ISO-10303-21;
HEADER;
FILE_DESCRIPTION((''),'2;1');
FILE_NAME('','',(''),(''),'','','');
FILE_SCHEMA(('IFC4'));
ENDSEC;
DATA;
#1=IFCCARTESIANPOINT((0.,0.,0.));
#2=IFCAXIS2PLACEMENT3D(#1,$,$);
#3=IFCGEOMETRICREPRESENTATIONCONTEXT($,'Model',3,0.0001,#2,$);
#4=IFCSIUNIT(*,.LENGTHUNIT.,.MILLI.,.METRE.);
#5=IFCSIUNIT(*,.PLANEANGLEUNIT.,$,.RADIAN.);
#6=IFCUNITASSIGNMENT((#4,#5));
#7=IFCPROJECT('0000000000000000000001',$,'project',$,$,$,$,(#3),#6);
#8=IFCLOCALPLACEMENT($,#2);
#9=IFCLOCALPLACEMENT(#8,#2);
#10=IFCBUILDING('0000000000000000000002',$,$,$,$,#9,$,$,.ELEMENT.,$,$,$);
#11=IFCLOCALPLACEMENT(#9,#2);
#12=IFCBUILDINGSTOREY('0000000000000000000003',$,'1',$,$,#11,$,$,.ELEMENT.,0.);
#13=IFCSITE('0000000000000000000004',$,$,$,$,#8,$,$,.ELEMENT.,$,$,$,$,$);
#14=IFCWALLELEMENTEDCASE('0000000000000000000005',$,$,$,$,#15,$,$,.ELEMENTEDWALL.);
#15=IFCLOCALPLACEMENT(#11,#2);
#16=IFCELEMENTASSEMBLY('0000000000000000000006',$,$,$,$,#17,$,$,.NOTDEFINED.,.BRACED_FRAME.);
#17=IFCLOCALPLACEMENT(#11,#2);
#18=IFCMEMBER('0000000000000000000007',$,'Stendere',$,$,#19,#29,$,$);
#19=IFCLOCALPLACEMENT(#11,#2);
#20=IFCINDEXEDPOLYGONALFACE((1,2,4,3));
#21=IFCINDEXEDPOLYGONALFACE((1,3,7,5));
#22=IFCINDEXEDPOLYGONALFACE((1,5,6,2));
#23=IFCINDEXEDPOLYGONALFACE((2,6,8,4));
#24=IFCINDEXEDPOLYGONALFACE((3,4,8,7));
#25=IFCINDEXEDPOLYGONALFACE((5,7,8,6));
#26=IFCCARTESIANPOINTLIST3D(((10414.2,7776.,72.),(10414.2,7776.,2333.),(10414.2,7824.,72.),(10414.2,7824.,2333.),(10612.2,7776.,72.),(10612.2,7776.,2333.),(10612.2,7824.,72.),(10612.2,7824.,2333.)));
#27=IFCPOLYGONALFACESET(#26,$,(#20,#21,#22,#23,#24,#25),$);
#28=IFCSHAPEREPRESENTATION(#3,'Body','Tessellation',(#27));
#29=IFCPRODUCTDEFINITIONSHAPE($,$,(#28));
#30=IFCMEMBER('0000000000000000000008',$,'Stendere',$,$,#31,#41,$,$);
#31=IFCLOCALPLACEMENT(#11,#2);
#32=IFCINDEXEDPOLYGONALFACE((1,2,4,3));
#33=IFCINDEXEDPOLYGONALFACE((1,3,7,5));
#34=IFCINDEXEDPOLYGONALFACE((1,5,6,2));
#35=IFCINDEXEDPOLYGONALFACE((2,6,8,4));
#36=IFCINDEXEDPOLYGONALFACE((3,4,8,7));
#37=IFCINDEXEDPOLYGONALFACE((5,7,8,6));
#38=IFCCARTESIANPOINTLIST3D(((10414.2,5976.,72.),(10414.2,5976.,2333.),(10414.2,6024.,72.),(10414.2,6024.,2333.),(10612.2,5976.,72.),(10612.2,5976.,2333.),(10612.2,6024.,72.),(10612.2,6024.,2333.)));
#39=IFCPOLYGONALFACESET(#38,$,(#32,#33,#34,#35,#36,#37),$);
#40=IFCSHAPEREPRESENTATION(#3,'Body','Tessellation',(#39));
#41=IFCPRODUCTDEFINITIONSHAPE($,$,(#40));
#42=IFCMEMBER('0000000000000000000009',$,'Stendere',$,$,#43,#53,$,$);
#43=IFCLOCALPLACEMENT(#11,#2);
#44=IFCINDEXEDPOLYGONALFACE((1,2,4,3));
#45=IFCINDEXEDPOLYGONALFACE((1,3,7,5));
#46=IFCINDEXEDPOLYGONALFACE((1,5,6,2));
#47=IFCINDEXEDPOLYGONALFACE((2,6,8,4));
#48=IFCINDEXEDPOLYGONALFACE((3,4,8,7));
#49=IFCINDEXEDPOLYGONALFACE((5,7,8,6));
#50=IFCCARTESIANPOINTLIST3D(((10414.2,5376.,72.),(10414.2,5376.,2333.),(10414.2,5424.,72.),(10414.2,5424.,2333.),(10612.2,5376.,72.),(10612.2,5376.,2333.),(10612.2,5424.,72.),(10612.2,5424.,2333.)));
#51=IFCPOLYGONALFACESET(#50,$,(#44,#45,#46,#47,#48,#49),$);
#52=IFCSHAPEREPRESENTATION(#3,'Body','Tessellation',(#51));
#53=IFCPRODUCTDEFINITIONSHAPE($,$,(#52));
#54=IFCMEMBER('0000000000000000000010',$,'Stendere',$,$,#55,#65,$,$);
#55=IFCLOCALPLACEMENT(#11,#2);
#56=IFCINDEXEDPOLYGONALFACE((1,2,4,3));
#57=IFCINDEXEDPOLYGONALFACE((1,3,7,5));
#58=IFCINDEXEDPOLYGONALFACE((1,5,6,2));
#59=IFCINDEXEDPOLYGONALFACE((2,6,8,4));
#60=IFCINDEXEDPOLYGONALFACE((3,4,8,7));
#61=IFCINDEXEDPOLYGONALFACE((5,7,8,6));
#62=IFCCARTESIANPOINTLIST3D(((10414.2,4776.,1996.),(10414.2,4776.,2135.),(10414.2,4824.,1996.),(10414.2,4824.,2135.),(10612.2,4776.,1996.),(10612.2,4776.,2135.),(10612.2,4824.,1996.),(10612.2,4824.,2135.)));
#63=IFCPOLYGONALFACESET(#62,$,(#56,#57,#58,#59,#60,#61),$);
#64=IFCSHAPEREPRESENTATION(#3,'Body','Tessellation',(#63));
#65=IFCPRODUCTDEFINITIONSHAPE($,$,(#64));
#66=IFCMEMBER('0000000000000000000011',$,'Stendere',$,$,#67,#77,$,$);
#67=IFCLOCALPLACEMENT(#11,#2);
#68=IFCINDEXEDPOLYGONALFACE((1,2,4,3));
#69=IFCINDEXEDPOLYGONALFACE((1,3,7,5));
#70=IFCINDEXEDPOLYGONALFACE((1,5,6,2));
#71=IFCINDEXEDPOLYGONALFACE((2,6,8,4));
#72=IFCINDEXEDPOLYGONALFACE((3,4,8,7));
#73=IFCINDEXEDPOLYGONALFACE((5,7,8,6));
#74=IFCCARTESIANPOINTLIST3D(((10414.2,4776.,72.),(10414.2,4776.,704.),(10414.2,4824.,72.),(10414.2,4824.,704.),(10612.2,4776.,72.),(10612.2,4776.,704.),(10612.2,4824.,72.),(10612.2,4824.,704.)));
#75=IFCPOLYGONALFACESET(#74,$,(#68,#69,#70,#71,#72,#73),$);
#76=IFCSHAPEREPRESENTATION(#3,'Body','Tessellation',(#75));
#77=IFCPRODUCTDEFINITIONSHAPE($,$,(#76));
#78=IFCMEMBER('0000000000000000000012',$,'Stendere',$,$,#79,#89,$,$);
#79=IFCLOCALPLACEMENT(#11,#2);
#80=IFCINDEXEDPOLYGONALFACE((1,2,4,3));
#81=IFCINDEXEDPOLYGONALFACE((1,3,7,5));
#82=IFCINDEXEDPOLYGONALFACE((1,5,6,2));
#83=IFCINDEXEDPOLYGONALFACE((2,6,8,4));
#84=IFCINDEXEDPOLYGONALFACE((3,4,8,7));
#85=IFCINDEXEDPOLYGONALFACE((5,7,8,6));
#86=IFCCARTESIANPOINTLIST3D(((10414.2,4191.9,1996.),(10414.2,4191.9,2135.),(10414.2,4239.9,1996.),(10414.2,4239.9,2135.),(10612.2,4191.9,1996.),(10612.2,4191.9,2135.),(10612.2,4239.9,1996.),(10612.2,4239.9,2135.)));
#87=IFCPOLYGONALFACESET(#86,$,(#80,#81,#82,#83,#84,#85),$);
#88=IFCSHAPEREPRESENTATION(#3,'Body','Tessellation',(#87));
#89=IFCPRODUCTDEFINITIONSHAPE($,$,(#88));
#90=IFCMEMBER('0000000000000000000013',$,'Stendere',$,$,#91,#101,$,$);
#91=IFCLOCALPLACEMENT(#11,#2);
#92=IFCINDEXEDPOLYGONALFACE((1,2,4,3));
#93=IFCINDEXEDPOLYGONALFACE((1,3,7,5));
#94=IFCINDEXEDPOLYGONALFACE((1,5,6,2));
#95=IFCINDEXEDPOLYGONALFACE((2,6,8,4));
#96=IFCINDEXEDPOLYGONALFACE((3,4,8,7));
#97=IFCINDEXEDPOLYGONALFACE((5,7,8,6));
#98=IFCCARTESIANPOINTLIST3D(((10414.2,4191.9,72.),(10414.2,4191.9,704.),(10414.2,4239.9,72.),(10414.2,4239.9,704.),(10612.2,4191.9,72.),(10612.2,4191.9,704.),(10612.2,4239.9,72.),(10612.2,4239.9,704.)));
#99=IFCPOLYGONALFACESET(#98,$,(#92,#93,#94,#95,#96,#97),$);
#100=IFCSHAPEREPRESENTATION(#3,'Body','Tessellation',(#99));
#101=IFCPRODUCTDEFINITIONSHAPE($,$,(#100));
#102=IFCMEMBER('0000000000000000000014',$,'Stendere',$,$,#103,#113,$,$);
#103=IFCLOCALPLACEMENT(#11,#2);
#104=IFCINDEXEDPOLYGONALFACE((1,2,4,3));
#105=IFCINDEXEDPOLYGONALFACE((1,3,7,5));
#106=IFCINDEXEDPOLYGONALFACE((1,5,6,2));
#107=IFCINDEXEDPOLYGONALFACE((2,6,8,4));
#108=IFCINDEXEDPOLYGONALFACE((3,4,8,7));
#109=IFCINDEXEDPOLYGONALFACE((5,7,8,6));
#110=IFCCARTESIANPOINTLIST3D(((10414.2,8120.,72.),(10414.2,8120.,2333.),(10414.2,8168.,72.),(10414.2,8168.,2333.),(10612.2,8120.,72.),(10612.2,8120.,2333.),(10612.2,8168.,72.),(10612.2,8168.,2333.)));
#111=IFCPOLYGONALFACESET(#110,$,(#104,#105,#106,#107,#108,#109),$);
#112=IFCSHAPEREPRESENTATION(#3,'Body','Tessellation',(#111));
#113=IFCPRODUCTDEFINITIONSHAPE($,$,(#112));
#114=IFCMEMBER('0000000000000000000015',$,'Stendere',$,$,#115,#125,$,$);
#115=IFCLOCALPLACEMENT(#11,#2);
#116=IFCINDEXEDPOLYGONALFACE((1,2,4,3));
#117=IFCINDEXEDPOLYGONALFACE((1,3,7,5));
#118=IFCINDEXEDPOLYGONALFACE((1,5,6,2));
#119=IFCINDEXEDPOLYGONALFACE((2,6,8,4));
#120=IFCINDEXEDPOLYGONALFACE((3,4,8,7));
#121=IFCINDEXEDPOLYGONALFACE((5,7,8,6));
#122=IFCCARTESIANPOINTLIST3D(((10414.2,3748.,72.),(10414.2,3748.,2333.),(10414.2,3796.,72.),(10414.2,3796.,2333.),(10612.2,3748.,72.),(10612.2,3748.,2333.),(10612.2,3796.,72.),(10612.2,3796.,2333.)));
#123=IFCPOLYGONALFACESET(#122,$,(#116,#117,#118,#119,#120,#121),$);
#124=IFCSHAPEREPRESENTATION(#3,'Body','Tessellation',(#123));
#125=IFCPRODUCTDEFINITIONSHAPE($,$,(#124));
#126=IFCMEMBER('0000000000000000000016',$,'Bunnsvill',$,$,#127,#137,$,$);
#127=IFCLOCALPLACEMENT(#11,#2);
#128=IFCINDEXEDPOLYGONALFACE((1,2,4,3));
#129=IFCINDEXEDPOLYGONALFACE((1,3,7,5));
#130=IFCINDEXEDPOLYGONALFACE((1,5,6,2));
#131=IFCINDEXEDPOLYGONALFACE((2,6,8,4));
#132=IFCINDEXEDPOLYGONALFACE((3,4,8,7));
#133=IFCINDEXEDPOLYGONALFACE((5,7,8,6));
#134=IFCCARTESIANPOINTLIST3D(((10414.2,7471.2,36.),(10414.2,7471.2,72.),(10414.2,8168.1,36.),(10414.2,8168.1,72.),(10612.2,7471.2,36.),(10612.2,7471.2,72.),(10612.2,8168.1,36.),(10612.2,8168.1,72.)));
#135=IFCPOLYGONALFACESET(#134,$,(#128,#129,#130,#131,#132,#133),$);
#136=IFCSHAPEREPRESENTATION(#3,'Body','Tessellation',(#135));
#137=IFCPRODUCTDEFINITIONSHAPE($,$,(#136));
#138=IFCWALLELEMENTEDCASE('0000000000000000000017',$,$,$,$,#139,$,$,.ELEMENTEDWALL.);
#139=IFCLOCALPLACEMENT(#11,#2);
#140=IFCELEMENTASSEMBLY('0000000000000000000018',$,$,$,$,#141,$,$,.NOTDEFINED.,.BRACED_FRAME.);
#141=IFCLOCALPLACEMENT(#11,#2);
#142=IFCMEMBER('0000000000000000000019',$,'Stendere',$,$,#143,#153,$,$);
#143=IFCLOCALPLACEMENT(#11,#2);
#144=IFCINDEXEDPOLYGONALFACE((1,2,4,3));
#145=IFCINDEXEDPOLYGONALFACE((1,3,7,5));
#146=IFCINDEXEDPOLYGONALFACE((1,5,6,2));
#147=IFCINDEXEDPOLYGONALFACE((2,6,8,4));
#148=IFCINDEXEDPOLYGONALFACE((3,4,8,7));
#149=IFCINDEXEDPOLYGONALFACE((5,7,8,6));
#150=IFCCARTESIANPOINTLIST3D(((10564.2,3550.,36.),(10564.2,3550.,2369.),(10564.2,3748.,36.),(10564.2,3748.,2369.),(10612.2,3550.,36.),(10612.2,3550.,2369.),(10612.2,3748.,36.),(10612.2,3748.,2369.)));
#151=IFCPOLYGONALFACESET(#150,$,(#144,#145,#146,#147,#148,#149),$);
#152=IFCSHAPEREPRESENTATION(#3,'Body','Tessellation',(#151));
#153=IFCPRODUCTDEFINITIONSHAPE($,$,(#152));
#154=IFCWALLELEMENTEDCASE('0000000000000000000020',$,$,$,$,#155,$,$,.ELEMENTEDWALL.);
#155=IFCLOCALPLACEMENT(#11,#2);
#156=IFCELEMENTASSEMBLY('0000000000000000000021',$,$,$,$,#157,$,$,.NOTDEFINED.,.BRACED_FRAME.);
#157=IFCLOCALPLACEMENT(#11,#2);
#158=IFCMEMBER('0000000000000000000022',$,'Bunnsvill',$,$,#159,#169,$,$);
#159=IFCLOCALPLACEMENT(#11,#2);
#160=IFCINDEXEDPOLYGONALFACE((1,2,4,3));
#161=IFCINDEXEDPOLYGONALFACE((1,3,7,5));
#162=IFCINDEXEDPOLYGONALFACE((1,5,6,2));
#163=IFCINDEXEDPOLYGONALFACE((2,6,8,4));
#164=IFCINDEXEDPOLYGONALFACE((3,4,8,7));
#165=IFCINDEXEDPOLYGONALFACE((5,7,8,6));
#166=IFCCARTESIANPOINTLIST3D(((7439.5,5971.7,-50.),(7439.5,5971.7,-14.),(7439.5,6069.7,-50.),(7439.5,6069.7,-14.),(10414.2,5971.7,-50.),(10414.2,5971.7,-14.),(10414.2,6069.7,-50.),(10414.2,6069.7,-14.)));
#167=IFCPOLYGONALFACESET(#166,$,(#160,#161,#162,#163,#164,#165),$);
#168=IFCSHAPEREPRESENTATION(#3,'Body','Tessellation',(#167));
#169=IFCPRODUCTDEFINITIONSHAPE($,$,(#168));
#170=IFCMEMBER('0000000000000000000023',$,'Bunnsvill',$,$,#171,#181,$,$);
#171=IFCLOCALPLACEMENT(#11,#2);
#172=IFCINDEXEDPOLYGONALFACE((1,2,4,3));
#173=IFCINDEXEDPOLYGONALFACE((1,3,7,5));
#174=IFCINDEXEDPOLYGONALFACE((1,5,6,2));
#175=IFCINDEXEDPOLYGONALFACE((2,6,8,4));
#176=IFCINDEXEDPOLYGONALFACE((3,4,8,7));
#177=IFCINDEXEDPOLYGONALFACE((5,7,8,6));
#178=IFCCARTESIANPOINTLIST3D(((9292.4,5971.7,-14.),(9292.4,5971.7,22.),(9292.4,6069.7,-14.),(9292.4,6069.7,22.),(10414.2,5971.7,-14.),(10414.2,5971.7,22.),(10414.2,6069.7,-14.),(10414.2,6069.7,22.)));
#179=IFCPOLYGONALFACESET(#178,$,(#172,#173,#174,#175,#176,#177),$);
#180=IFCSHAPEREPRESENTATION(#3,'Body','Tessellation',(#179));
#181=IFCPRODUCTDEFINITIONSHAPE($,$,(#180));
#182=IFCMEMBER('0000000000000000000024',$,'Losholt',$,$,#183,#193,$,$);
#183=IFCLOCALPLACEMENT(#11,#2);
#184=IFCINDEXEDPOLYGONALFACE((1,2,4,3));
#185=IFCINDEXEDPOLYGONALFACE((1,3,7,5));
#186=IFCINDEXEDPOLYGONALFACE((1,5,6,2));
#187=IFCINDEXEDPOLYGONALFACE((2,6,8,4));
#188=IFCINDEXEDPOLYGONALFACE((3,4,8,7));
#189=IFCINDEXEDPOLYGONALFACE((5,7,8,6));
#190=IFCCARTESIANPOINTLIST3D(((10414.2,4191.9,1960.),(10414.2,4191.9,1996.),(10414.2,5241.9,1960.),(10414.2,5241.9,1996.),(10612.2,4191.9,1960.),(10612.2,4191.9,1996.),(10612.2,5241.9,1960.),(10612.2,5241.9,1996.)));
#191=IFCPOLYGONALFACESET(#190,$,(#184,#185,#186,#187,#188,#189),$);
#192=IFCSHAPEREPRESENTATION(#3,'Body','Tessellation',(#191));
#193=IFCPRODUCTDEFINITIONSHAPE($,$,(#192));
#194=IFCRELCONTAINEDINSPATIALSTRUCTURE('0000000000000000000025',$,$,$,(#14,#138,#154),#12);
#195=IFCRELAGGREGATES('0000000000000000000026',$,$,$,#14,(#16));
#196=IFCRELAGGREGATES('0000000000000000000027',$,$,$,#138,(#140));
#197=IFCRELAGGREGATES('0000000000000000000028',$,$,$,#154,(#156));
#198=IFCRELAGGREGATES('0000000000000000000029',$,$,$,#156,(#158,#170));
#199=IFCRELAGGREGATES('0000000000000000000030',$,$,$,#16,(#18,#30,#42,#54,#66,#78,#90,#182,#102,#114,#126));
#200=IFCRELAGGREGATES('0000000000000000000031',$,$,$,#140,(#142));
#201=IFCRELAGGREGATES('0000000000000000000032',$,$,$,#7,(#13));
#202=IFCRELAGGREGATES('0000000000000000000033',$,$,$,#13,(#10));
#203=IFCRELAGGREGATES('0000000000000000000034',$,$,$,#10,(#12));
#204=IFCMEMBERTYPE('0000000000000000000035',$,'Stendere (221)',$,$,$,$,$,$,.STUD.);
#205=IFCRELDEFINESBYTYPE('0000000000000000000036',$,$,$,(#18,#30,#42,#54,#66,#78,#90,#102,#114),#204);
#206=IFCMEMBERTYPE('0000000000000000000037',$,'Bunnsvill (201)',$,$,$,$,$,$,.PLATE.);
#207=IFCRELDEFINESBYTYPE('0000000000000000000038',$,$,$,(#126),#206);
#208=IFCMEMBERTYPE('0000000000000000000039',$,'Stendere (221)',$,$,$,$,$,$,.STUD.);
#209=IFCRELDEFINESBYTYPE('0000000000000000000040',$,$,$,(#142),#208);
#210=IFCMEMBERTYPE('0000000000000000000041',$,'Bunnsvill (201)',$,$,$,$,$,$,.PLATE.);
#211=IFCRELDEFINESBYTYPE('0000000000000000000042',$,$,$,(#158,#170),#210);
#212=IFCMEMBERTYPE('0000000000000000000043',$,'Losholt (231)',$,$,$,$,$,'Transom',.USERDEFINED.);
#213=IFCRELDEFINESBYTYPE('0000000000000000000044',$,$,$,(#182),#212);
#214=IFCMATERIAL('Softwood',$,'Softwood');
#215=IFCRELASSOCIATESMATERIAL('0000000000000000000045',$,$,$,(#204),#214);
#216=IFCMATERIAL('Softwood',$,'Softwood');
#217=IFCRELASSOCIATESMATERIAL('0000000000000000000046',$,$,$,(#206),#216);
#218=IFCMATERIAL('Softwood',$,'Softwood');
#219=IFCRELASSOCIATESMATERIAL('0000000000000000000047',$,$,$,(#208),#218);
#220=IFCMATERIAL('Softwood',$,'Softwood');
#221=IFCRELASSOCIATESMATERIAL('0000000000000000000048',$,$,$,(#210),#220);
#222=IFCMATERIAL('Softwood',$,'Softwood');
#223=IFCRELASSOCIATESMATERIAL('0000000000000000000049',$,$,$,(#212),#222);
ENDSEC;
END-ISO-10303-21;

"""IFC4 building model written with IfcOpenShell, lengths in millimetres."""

from ifc_helpers import new_model, si_unit, frame, origin, place, context, project, spatial, rectangle, extrude, material, material_profile, profile_set, type_object, element, aggregate, save


model = new_model("IFC4")

# Units and contexts
model_context = context("Model", 3, precision=0.0001, world=origin())
ifc_project = project(units=[si_unit("LENGTHUNIT", "METRE", prefix="MILLI"), si_unit("PLANEANGLEUNIT", "RADIAN")], contexts=[model_context])

# Site, building, storey
site_placement = place(None, origin())
site = spatial("IfcSite", under=ifc_project, at=site_placement, CompositionType="ELEMENT")
building_placement = place(site_placement, origin())
building = spatial("IfcBuilding", under=site, at=building_placement, CompositionType="ELEMENT")
storey_placement = place(building_placement, origin())
storey = spatial("IfcBuildingStorey", under=building, at=storey_placement, Name="1", CompositionType="ELEMENT", Elevation=0.0)

# Wall, element assembly, members
wall_1_placement = place(storey_placement, frame((10414.2, 3748.0, 0.0), z_axis=(1.0, 0.0, 0.0), x_axis=(0.0, 1.0, 0.0)))
wall_1 = element("IfcWallElementedCase", 1, at=wall_1_placement, inside=storey, PredefinedType="ELEMENTEDWALL")
assembly_1_placement = place(wall_1_placement, origin())
assembly_1 = element("IfcElementAssembly", 2, at=assembly_1_placement, AssemblyPlace="NOTDEFINED", PredefinedType="BRACED_FRAME")
aggregate(wall_1, [assembly_1])
ifc_material_1 = material(Name="Softwood", Category="Softwood")
ifc_material_profile_1 = material_profile(ifc_material_1, rectangle(XDim=48.0, YDim=198.0), Name="Stendere (221)")
ifc_profile_set_1 = profile_set([ifc_material_profile_1])
member_type_1 = type_object("IfcMemberType", Name="Stendere (221)", PredefinedType="STUD", material=ifc_profile_set_1)
member_1_placement = place(assembly_1_placement, frame((4052.0, 72.0, 0.0), z_axis=(0.0, 1.0, 0.0), x_axis=(-1.0, 0.0, 0.0)))
member_1 = element("IfcMember", 3, at=member_1_placement, type_object=member_type_1, Name="Stendere", context=model_context, shape_type="SweptSolid", body=[
    extrude(rectangle(XDim=48.0, YDim=198.0), frame((0.0, 99.0, 0.0)), (0.0, 0.0, 1.0), 2261.0),
])
member_2_placement = place(assembly_1_placement, frame((2252.0, 72.0, 0.0), z_axis=(0.0, 1.0, 0.0), x_axis=(-1.0, 0.0, 0.0)))
member_2 = element("IfcMember", 4, at=member_2_placement, type_object=member_type_1, Name="Stendere", context=model_context, shape_type="SweptSolid", body=[
    extrude(rectangle(XDim=48.0, YDim=198.0), frame((0.0, 99.0, 0.0)), (0.0, 0.0, 1.0), 2261.0),
])
member_3_placement = place(assembly_1_placement, frame((1652.0, 72.0, 0.0), z_axis=(0.0, 1.0, 0.0), x_axis=(-1.0, 0.0, 0.0)))
member_3 = element("IfcMember", 5, at=member_3_placement, type_object=member_type_1, Name="Stendere", context=model_context, shape_type="SweptSolid", body=[
    extrude(rectangle(XDim=48.0, YDim=198.0), frame((0.0, 99.0, 0.0)), (0.0, 0.0, 1.0), 2261.0),
])
member_4_placement = place(assembly_1_placement, frame((1052.0, 1996.0, 0.0), z_axis=(0.0, 1.0, 0.0), x_axis=(-1.0, 0.0, 0.0)))
member_4 = element("IfcMember", 6, at=member_4_placement, type_object=member_type_1, Name="Stendere", context=model_context, shape_type="SweptSolid", body=[
    extrude(rectangle(XDim=48.0, YDim=198.0), frame((0.0, 99.0, 0.0)), (0.0, 0.0, 1.0), 139.0),
])
member_5_placement = place(assembly_1_placement, frame((1052.0, 72.0, 0.0), z_axis=(0.0, 1.0, 0.0), x_axis=(-1.0, 0.0, 0.0)))
member_5 = element("IfcMember", 7, at=member_5_placement, type_object=member_type_1, Name="Stendere", context=model_context, shape_type="SweptSolid", body=[
    extrude(rectangle(XDim=48.0, YDim=198.0), frame((0.0, 99.0, 0.0)), (0.0, 0.0, 1.0), 632.0),
])
member_6_placement = place(assembly_1_placement, frame((467.9, 1996.0, 0.0), z_axis=(0.0, 1.0, 0.0), x_axis=(-1.0, 0.0, 0.0)))
member_6 = element("IfcMember", 8, at=member_6_placement, type_object=member_type_1, Name="Stendere", context=model_context, shape_type="SweptSolid", body=[
    extrude(rectangle(XDim=48.0, YDim=198.0), frame((0.0, 99.0, 0.0)), (0.0, 0.0, 1.0), 139.0),
])
member_7_placement = place(assembly_1_placement, frame((467.9, 72.0, 0.0), z_axis=(0.0, 1.0, 0.0), x_axis=(-1.0, 0.0, 0.0)))
member_7 = element("IfcMember", 9, at=member_7_placement, type_object=member_type_1, Name="Stendere", context=model_context, shape_type="SweptSolid", body=[
    extrude(rectangle(XDim=48.0, YDim=198.0), frame((0.0, 99.0, 0.0)), (0.0, 0.0, 1.0), 632.0),
])
member_8_placement = place(assembly_1_placement, frame((4396.1, 72.0, 0.0), z_axis=(0.0, 1.0, 0.0), x_axis=(-1.0, 0.0, 0.0)))
member_8 = element("IfcMember", 10, at=member_8_placement, type_object=member_type_1, Name="Stendere", context=model_context, shape_type="SweptSolid", body=[
    extrude(rectangle(XDim=48.0, YDim=198.0), frame((0.0, 99.0, 0.0)), (0.0, 0.0, 1.0), 2261.0),
])
member_9_placement = place(assembly_1_placement, frame((24.0, 72.0, 0.0), z_axis=(0.0, 1.0, 0.0), x_axis=(-1.0, 0.0, 0.0)))
member_9 = element("IfcMember", 11, at=member_9_placement, type_object=member_type_1, Name="Stendere", context=model_context, shape_type="SweptSolid", body=[
    extrude(rectangle(XDim=48.0, YDim=198.0), frame((0.0, 99.0, 0.0)), (0.0, 0.0, 1.0), 2261.0),
])
ifc_material_2 = material(Name="Softwood", Category="Softwood")
ifc_material_profile_2 = material_profile(ifc_material_2, rectangle(XDim=36.0, YDim=198.0), Name="Bunnsvill (201)")
ifc_profile_set_2 = profile_set([ifc_material_profile_2])
member_type_2 = type_object("IfcMemberType", Name="Bunnsvill (201)", PredefinedType="PLATE", material=ifc_profile_set_2)
member_10_placement = place(assembly_1_placement, frame((3723.2, 54.0, 0.0), z_axis=(1.0, 0.0, 0.0), x_axis=(0.0, 1.0, 0.0)))
member_10 = element("IfcMember", 12, at=member_10_placement, type_object=member_type_2, Name="Bunnsvill", context=model_context, shape_type="SweptSolid", body=[
    extrude(rectangle(XDim=36.0, YDim=198.0), frame((0.0, 99.0, 0.0)), (0.0, 0.0, 1.0), 696.9),
])

# Wall, element assembly, member
wall_2_placement = place(storey_placement, frame((6576.0, 3748.0, 0.0), z_axis=(0.0, -1.0, 0.0)))
wall_2 = element("IfcWallElementedCase", 13, at=wall_2_placement, inside=storey, PredefinedType="ELEMENTEDWALL")
assembly_2_placement = place(wall_2_placement, origin())
assembly_2 = element("IfcElementAssembly", 14, at=assembly_2_placement, AssemblyPlace="NOTDEFINED", PredefinedType="BRACED_FRAME")
aggregate(wall_2, [assembly_2])
ifc_material_3 = material(Name="Softwood", Category="Softwood")
ifc_material_profile_3 = material_profile(ifc_material_3, rectangle(XDim=48.0, YDim=198.0), Name="Stendere (221)")
ifc_profile_set_3 = profile_set([ifc_material_profile_3])
member_type_3 = type_object("IfcMemberType", Name="Stendere (221)", PredefinedType="STUD", material=ifc_profile_set_3)
member_11_placement = place(assembly_2_placement, frame((4012.2, 36.0, 0.0), z_axis=(0.0, 1.0, 0.0), x_axis=(-1.0, 0.0, 0.0)))
member_11 = element("IfcMember", 15, at=member_11_placement, type_object=member_type_3, Name="Stendere", context=model_context, shape_type="SweptSolid", body=[
    extrude(rectangle(XDim=48.0, YDim=198.0), frame((0.0, 99.0, 0.0)), (0.0, 0.0, 1.0), 2333.0),
])

# Wall, element assembly, members
wall_3_placement = place(storey_placement, frame((10414.2, 5971.7, -50.0), z_axis=(0.0, 1.0, 0.0), x_axis=(-1.0, 0.0, 0.0)))
wall_3 = element("IfcWallElementedCase", 16, at=wall_3_placement, inside=storey, PredefinedType="ELEMENTEDWALL")
assembly_3_placement = place(wall_3_placement, origin())
assembly_3 = element("IfcElementAssembly", 17, at=assembly_3_placement, AssemblyPlace="NOTDEFINED", PredefinedType="BRACED_FRAME")
aggregate(wall_3, [assembly_3])
ifc_material_4 = material(Name="Softwood", Category="Softwood")
ifc_material_profile_4 = material_profile(ifc_material_4, rectangle(XDim=36.0, YDim=98.0), Name="Bunnsvill (201)")
ifc_profile_set_4 = profile_set([ifc_material_profile_4])
member_type_4 = type_object("IfcMemberType", Name="Bunnsvill (201)", PredefinedType="PLATE", material=ifc_profile_set_4)
member_12_placement = place(assembly_3_placement, frame((0.0, 18.0, 0.0), z_axis=(1.0, 0.0, 0.0), x_axis=(0.0, 1.0, 0.0)))
member_12 = element("IfcMember", 18, at=member_12_placement, type_object=member_type_4, Name="Bunnsvill", context=model_context, shape_type="SweptSolid", body=[
    extrude(rectangle(XDim=36.0, YDim=98.0), frame((0.0, 49.0, 0.0)), (0.0, 0.0, 1.0), 2974.7),
])
member_13_placement = place(assembly_3_placement, frame((0.0, 54.0, 0.0), z_axis=(1.0, 0.0, 0.0), x_axis=(0.0, 1.0, 0.0)))
member_13 = element("IfcMember", 19, at=member_13_placement, type_object=member_type_4, Name="Bunnsvill", context=model_context, shape_type="SweptSolid", body=[
    extrude(rectangle(XDim=36.0, YDim=98.0), frame((0.0, 49.0, 0.0)), (0.0, 0.0, 1.0), 1121.8),
])

# Member
ifc_material_5 = material(Name="Softwood", Category="Softwood")
ifc_material_profile_5 = material_profile(ifc_material_5, rectangle(XDim=36.0, YDim=198.0), Name="Losholt (231)")
ifc_profile_set_5 = profile_set([ifc_material_profile_5])
member_type_5 = type_object("IfcMemberType", Name="Losholt (231)", ElementType="Transom", PredefinedType="USERDEFINED", material=ifc_profile_set_5)
member_14_placement = place(assembly_1_placement, frame((443.9, 1978.0, 0.0), z_axis=(1.0, 0.0, 0.0), x_axis=(0.0, 1.0, 0.0)))
member_14 = element("IfcMember", 20, at=member_14_placement, type_object=member_type_5, Name="Losholt", context=model_context, shape_type="SweptSolid", body=[
    extrude(rectangle(XDim=36.0, YDim=198.0), frame((0.0, 99.0, 0.0)), (0.0, 0.0, 1.0), 1050.0),
])

aggregate(assembly_3, [member_12, member_13])
aggregate(assembly_1, [member_1, member_2, member_3, member_4, member_5, member_6, member_7, member_14, member_8, member_9, member_10])
aggregate(assembly_2, [member_11])

save(model, "model.ifc")
